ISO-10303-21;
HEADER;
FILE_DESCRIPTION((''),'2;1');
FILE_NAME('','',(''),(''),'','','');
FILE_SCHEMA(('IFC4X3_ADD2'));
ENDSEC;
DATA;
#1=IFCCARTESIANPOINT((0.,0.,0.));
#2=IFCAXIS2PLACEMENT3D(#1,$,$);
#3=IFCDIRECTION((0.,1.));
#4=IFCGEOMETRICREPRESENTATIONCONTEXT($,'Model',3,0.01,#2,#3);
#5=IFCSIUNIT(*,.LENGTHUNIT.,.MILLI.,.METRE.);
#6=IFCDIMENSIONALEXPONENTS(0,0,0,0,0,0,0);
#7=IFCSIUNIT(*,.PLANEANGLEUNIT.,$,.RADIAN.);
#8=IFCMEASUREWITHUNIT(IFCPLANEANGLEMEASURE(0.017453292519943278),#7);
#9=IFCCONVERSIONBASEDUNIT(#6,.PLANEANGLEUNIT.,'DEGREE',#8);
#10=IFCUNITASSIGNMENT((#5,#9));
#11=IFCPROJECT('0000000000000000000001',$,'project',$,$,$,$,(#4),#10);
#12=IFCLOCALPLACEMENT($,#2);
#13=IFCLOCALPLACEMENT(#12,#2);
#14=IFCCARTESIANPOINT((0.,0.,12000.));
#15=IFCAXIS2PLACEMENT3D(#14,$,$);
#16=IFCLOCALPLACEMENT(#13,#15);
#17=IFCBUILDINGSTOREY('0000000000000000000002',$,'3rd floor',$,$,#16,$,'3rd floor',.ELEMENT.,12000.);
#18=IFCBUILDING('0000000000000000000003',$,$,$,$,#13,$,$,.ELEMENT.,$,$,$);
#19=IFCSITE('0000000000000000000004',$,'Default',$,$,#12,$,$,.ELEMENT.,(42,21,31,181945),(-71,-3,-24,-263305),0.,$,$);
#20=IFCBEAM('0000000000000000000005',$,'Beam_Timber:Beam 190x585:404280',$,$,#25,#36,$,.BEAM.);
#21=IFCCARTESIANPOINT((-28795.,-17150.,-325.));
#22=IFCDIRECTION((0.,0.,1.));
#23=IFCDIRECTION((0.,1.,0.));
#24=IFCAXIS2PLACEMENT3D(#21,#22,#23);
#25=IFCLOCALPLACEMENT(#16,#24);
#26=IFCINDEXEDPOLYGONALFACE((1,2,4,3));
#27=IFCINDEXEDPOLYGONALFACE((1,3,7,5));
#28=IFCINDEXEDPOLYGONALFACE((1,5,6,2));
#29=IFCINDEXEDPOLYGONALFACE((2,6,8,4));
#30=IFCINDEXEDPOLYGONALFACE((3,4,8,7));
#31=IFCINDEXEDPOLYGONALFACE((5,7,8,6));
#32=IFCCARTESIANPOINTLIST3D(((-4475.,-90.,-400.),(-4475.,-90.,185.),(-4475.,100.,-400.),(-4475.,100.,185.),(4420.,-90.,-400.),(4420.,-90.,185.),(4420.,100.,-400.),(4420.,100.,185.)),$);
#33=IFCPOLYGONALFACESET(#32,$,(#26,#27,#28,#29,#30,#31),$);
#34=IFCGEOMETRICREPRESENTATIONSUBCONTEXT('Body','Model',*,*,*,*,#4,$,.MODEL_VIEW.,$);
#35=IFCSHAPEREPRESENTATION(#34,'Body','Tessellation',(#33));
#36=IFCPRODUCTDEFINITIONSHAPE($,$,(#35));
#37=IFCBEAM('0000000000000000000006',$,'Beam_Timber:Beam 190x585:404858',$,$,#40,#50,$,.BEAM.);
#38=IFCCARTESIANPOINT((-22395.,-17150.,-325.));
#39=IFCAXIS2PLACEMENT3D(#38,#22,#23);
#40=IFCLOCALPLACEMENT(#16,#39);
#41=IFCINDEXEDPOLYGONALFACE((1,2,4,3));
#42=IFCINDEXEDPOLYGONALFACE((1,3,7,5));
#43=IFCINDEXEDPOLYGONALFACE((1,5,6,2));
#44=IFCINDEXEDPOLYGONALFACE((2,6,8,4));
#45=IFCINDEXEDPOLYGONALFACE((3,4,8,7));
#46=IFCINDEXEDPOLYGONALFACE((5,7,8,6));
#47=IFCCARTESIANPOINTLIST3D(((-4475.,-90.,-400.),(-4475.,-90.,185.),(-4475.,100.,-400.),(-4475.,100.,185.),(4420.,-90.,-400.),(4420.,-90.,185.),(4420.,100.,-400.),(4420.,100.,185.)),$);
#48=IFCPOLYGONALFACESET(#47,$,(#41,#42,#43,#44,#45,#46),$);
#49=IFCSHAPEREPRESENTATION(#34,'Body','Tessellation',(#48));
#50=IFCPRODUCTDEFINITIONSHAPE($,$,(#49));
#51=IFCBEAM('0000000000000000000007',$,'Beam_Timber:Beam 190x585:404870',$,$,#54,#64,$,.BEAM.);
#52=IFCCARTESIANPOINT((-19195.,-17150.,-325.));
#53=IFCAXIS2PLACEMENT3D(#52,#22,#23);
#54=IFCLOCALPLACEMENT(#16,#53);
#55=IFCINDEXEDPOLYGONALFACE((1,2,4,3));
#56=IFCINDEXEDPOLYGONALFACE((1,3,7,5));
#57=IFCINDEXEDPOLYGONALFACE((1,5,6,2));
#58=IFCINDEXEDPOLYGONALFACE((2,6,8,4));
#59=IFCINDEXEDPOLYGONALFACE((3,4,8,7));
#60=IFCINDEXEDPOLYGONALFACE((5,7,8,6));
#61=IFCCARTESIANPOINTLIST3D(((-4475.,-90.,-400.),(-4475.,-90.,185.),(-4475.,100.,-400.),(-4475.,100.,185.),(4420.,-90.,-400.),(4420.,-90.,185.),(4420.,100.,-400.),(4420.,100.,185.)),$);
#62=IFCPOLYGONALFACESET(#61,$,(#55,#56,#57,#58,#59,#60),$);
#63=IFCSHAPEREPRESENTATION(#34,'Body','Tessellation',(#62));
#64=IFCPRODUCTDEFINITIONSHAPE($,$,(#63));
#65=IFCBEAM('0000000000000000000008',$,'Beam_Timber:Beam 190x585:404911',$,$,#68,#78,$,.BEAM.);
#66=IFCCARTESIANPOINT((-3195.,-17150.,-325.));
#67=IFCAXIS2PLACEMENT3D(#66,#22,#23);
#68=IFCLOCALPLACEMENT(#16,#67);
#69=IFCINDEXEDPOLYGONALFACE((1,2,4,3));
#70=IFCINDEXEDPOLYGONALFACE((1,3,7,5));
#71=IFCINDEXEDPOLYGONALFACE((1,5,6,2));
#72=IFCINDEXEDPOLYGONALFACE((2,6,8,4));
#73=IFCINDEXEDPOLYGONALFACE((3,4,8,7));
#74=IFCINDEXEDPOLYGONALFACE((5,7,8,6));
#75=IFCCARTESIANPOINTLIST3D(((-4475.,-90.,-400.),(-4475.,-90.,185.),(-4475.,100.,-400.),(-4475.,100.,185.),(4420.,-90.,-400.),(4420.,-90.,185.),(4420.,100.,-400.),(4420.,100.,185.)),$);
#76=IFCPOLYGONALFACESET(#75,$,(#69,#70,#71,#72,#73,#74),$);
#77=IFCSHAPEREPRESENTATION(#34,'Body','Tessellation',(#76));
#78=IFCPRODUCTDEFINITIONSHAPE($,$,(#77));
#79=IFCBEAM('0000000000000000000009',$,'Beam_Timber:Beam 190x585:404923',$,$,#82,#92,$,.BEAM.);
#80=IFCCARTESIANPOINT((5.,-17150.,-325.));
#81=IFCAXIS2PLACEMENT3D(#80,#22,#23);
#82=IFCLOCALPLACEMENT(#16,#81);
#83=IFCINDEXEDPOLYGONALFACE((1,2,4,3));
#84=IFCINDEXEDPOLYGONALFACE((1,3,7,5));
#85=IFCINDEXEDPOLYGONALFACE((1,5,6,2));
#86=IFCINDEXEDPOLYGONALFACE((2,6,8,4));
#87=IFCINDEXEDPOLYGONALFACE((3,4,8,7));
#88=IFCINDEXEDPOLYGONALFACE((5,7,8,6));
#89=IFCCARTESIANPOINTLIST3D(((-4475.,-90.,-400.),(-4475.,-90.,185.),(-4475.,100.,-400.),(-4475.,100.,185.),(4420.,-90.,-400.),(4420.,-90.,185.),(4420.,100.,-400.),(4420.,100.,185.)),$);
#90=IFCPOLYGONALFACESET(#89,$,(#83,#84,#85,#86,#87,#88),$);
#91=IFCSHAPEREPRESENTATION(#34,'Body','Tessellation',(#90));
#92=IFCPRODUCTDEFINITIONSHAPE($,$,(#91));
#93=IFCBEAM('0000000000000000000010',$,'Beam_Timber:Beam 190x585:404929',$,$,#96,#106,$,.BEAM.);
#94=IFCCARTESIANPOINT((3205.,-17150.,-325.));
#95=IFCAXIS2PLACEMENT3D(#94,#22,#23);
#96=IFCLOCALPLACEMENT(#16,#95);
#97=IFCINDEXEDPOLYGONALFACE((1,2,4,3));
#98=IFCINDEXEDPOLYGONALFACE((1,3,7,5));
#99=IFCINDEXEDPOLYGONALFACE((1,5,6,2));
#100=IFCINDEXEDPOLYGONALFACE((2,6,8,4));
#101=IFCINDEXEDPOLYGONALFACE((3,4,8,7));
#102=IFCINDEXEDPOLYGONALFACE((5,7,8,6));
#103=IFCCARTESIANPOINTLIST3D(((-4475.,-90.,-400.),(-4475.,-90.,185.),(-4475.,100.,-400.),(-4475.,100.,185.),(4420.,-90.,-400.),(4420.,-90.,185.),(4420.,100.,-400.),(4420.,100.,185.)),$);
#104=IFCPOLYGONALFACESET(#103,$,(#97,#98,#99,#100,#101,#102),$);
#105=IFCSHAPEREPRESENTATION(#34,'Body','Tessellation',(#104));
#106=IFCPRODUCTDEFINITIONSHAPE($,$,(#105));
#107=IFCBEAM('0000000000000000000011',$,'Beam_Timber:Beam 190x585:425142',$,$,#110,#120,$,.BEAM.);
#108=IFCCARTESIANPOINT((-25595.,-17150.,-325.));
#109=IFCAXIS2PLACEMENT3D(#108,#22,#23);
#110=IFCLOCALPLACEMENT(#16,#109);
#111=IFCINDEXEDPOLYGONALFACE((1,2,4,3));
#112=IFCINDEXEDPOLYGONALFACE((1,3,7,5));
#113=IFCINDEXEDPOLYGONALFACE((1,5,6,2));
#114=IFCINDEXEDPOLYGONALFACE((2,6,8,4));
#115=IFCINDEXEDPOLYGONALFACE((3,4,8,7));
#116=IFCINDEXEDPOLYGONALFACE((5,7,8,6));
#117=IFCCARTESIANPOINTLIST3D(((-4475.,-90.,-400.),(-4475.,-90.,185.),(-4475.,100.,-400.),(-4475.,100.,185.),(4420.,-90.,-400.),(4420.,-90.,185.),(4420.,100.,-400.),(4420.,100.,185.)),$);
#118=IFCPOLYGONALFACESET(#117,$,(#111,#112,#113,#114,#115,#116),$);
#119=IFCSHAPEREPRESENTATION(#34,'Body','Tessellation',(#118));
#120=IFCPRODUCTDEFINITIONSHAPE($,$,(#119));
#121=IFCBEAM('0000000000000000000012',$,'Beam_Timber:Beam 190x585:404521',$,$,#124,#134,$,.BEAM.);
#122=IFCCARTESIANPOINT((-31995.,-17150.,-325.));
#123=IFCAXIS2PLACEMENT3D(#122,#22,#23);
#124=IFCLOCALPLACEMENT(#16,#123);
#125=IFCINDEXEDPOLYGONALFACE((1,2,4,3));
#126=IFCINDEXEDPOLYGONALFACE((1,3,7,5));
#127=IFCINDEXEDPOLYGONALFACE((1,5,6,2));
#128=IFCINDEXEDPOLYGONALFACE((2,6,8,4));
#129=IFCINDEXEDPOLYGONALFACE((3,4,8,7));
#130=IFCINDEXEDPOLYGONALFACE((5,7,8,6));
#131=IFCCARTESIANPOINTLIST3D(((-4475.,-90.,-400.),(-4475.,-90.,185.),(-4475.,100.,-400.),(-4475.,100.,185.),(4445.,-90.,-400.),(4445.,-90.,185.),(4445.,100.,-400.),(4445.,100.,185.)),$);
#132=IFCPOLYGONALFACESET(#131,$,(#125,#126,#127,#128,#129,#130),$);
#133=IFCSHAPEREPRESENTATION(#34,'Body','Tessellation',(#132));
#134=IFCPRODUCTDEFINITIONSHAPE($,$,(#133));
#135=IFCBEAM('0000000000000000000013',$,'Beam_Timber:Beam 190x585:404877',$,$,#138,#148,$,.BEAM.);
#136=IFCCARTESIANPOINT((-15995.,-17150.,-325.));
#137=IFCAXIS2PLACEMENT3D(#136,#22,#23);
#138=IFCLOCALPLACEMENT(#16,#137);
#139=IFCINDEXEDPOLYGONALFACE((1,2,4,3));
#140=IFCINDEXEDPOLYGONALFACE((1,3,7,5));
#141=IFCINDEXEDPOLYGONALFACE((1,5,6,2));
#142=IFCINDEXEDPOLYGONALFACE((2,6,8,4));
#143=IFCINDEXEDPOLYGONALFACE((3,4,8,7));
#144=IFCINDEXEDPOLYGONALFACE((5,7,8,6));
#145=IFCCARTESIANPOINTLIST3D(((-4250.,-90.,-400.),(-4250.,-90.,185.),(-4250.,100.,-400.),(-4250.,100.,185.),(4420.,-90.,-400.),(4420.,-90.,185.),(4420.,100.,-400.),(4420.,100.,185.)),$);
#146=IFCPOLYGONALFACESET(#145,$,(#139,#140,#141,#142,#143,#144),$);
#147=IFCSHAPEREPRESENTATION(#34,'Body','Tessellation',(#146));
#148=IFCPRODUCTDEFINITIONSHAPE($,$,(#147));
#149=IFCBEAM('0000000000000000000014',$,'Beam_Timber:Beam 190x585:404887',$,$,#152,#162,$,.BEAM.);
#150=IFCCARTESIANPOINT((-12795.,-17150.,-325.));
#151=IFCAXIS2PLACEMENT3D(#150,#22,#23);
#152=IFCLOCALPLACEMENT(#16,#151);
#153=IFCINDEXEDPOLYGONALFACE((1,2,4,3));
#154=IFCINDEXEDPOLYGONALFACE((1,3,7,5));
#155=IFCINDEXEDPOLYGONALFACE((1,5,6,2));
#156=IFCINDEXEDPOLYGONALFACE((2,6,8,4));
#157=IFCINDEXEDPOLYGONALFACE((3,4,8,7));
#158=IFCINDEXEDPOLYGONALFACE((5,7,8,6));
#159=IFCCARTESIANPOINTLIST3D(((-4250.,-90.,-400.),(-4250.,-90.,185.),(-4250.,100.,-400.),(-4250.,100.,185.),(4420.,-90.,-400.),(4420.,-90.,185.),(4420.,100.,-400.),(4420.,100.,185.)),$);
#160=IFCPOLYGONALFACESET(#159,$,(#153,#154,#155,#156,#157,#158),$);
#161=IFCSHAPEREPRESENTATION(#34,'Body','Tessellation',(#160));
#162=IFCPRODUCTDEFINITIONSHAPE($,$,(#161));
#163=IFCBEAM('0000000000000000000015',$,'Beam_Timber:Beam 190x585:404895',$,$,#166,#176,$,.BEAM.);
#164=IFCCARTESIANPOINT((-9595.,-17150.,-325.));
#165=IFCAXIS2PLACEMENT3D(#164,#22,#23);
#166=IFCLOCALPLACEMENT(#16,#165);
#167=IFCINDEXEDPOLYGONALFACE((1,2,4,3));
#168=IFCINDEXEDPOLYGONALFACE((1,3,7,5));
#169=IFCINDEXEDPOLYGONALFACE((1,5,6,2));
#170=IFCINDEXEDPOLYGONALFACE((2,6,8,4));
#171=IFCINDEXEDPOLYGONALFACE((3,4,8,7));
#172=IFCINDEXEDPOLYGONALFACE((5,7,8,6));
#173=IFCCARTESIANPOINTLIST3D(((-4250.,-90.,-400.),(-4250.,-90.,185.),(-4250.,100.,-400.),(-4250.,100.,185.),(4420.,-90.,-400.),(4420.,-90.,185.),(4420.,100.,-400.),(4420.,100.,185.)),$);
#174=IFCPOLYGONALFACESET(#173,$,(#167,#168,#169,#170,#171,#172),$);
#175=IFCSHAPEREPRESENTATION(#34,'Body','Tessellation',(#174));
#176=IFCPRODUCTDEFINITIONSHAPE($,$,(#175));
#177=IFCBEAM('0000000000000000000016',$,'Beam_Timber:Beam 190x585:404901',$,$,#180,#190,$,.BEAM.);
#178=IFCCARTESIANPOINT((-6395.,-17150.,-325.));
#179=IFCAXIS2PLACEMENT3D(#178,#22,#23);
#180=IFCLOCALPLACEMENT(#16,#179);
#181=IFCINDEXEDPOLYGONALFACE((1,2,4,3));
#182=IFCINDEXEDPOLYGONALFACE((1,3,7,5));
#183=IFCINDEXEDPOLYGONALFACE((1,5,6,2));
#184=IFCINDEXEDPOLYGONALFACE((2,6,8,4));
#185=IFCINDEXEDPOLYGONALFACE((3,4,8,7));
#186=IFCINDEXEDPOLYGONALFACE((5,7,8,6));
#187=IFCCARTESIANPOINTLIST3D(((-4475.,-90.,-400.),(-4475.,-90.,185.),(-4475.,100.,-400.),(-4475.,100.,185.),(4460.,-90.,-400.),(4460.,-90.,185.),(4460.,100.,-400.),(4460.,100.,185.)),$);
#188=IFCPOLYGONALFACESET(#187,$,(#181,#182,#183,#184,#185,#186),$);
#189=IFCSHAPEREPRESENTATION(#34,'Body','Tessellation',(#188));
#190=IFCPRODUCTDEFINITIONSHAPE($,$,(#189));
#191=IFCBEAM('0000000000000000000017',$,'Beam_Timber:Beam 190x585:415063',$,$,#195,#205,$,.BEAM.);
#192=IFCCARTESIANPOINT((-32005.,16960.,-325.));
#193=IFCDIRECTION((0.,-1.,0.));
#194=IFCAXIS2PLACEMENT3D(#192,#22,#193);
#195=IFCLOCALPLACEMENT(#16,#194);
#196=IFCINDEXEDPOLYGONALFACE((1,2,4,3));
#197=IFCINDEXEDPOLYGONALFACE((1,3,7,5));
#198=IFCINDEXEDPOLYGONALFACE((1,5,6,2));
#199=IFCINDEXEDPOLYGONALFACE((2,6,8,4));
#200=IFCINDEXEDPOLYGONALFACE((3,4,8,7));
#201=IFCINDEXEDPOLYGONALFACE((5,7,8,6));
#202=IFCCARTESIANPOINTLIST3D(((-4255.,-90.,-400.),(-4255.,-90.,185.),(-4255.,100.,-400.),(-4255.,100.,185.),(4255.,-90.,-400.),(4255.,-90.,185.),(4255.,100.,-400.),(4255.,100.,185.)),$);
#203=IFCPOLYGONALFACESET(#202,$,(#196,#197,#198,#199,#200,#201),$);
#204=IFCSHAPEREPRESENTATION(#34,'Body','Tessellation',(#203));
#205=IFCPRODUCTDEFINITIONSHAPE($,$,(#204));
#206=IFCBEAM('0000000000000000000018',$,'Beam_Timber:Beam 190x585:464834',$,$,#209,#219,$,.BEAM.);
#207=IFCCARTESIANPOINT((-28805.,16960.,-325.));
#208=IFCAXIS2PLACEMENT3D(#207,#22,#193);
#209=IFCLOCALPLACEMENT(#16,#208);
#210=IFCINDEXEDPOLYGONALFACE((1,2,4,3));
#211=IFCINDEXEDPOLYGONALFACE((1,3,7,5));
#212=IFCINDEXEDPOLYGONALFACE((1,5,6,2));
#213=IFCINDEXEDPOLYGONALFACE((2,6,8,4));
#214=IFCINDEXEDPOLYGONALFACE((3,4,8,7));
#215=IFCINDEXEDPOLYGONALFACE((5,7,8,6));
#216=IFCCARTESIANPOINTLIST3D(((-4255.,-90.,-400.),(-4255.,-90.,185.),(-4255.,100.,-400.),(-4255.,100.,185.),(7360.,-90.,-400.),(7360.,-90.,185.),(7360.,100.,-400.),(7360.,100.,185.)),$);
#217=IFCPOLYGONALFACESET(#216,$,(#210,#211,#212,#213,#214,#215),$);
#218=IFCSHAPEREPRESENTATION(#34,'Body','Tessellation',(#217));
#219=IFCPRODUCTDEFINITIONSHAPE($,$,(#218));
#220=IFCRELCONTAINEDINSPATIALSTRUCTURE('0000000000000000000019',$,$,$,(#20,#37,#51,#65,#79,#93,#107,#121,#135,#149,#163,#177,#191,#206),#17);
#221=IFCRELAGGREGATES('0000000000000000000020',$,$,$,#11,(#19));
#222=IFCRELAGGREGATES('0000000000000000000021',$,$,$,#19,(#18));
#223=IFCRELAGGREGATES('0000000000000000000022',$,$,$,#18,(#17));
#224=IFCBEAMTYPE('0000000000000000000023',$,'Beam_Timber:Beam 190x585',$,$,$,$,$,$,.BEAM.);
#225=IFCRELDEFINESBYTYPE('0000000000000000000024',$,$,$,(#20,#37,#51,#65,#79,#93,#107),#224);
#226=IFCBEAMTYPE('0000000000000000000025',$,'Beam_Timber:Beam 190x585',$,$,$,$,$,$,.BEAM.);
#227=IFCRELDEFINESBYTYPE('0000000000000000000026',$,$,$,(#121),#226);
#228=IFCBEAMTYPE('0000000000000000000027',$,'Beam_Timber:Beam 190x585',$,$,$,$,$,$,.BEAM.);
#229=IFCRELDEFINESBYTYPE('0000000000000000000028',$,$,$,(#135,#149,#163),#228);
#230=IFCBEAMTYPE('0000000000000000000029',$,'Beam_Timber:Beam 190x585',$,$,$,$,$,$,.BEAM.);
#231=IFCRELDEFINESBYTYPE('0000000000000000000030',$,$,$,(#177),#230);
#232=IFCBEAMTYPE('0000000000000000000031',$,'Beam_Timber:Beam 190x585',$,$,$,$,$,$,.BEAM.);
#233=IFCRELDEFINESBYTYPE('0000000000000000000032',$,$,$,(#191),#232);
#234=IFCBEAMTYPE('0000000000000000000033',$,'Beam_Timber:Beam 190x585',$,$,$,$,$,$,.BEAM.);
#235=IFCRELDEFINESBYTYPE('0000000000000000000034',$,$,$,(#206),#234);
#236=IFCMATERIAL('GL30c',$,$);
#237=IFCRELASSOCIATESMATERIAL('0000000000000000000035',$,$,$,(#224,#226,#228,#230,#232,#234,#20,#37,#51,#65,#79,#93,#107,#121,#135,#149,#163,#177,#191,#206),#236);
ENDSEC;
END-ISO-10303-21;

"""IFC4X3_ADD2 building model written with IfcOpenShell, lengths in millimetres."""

from ifc_helpers import new_model, entity, si_unit, converted_unit, direction, frame, origin, origin_2d_with_axis, place, context, subcontext, project, spatial, rectangle, extrude, source, transform, mapped, material, material_profile, profile_set, profile_usage, type_object, type_shapes, element, save


model = new_model("IFC4X3_ADD2")

# Units and contexts
model_context = context("Model", 3, precision=0.01, world=origin(), true_north=direction((0.0, 1.0)))
body_context = subcontext(model_context, "Body", "Model", "MODEL_VIEW")
ifc_project = project(units=[si_unit("LENGTHUNIT", "METRE", prefix="MILLI"), converted_unit("PLANEANGLEUNIT", "DEGREE", entity("IfcPlaneAngleMeasure", 0.017453292519943278), si_unit("PLANEANGLEUNIT", "RADIAN"), dimensions=[0, 0, 0, 0, 0, 0, 0])], contexts=[model_context])

# Site, building, storey
site_placement = place(None, origin())
site = spatial("IfcSite", under=ifc_project, at=site_placement, Name="Default", CompositionType="ELEMENT", RefLatitude=(42, 21, 31, 181945), RefLongitude=(-71, -3, -24, -263305), RefElevation=0.0)
building_placement = place(site_placement, origin())
building = spatial("IfcBuilding", under=site, at=building_placement, CompositionType="ELEMENT")
storey_placement = place(building_placement, frame((0.0, 0.0, 12000.0)))
storey = spatial("IfcBuildingStorey", under=building, at=storey_placement, Name="3rd floor", LongName="3rd floor", CompositionType="ELEMENT", Elevation=12000.0)

# Beams
ifc_material_1 = material(Name="GL30c")
ifc_material_profile_1 = material_profile(ifc_material_1, rectangle(XDim=5490.0, YDim=190.0, at=origin_2d_with_axis()), Name="Beam 190x585")
ifc_profile_set_1 = profile_set([ifc_material_profile_1], Name="Beam 190x585")
ifc_profile_usage_1 = profile_usage(ifc_profile_set_1, cardinal=8)
beam_type_1 = type_object("IfcBeamType", Name="Beam_Timber:Beam 190x585", PredefinedType="BEAM", material=ifc_profile_set_1)
shared_shape_1 = source(origin(), body_context, "Body", "SweptSolid", [
    extrude(rectangle(XDim=8895.0, YDim=190.0, at=origin_2d_with_axis()), frame((-27.5, 5.0, -400.0), z_axis=(0.0, 0.0, 1.0), x_axis=(-1.0, 0.0, 0.0)), (0.0, 0.0, 1.0), 585.0),
])
type_shapes(beam_type_1, [shared_shape_1])
for number, where, z_axis, x_axis, name in (
    (1, (-28795.0, -17150.0, -325.0), (0.0, 0.0, 1.0), (0.0, 1.0, 0.0), "Beam_Timber:Beam 190x585:404280"),
    (2, (-22395.0, -17150.0, -325.0), (0.0, 0.0, 1.0), (0.0, 1.0, 0.0), "Beam_Timber:Beam 190x585:404858"),
    (3, (-19195.0, -17150.0, -325.0), (0.0, 0.0, 1.0), (0.0, 1.0, 0.0), "Beam_Timber:Beam 190x585:404870"),
    (4, (-3195.0, -17150.0, -325.0), (0.0, 0.0, 1.0), (0.0, 1.0, 0.0), "Beam_Timber:Beam 190x585:404911"),
    (5, (5.0, -17150.0, -325.0), (0.0, 0.0, 1.0), (0.0, 1.0, 0.0), "Beam_Timber:Beam 190x585:404923"),
    (6, (3205.0, -17150.0, -325.0), (0.0, 0.0, 1.0), (0.0, 1.0, 0.0), "Beam_Timber:Beam 190x585:404929"),
    (7, (-25595.0, -17150.0, -325.0), (0.0, 0.0, 1.0), (0.0, 1.0, 0.0), "Beam_Timber:Beam 190x585:425142"),
):
    element("IfcBeam", number, at=place(storey_placement, frame(where, z_axis=z_axis, x_axis=x_axis)), inside=storey, type_object=beam_type_1, material=ifc_profile_usage_1, Name=name, PredefinedType="BEAM", context=body_context, shape_type="MappedRepresentation", body=[
        mapped(shared_shape_1, transform((0.0, 0.0, 0.0), scale=1.0)),
    ])
beam_type_2 = type_object("IfcBeamType", Name="Beam_Timber:Beam 190x585", PredefinedType="BEAM", material=ifc_profile_set_1)
shared_shape_2 = source(origin(), body_context, "Body", "SweptSolid", [
    extrude(rectangle(XDim=8920.0, YDim=190.0, at=origin_2d_with_axis()), frame((-15.0, 5.0, -400.0), z_axis=(0.0, 0.0, 1.0), x_axis=(-1.0, 0.0, 0.0)), (0.0, 0.0, 1.0), 585.0),
])
type_shapes(beam_type_2, [shared_shape_2])
beam_1_placement = place(storey_placement, frame((-31995.0, -17150.0, -325.0), z_axis=(0.0, 0.0, 1.0), x_axis=(0.0, 1.0, 0.0)))
element("IfcBeam", 8, at=beam_1_placement, inside=storey, type_object=beam_type_2, material=ifc_profile_usage_1, Name="Beam_Timber:Beam 190x585:404521", PredefinedType="BEAM", context=body_context, shape_type="MappedRepresentation", body=[
    mapped(shared_shape_2, transform((0.0, 0.0, 0.0), scale=1.0)),
])
beam_type_3 = type_object("IfcBeamType", Name="Beam_Timber:Beam 190x585", PredefinedType="BEAM", material=ifc_profile_set_1)
shared_shape_3 = source(origin(), body_context, "Body", "SweptSolid", [
    extrude(rectangle(XDim=8670.0, YDim=190.0, at=origin_2d_with_axis()), frame((85.0, 5.0, -400.0), z_axis=(0.0, 0.0, 1.0), x_axis=(-1.0, 0.0, 0.0)), (0.0, 0.0, 1.0), 585.0),
])
type_shapes(beam_type_3, [shared_shape_3])
for number, where, z_axis, x_axis, name in (
    (9, (-15995.0, -17150.0, -325.0), (0.0, 0.0, 1.0), (0.0, 1.0, 0.0), "Beam_Timber:Beam 190x585:404877"),
    (10, (-12795.0, -17150.0, -325.0), (0.0, 0.0, 1.0), (0.0, 1.0, 0.0), "Beam_Timber:Beam 190x585:404887"),
    (11, (-9595.0, -17150.0, -325.0), (0.0, 0.0, 1.0), (0.0, 1.0, 0.0), "Beam_Timber:Beam 190x585:404895"),
):
    element("IfcBeam", number, at=place(storey_placement, frame(where, z_axis=z_axis, x_axis=x_axis)), inside=storey, type_object=beam_type_3, material=ifc_profile_usage_1, Name=name, PredefinedType="BEAM", context=body_context, shape_type="MappedRepresentation", body=[
        mapped(shared_shape_3, transform((0.0, 0.0, 0.0), scale=1.0)),
    ])
beam_type_4 = type_object("IfcBeamType", Name="Beam_Timber:Beam 190x585", PredefinedType="BEAM", material=ifc_profile_set_1)
shared_shape_4 = source(origin(), body_context, "Body", "SweptSolid", [
    extrude(rectangle(XDim=8935.0, YDim=190.0, at=origin_2d_with_axis()), frame((-7.5, 5.0, -400.0), z_axis=(0.0, 0.0, 1.0), x_axis=(-1.0, 0.0, 0.0)), (0.0, 0.0, 1.0), 585.0),
])
type_shapes(beam_type_4, [shared_shape_4])
beam_2_placement = place(storey_placement, frame((-6395.0, -17150.0, -325.0), z_axis=(0.0, 0.0, 1.0), x_axis=(0.0, 1.0, 0.0)))
element("IfcBeam", 12, at=beam_2_placement, inside=storey, type_object=beam_type_4, material=ifc_profile_usage_1, Name="Beam_Timber:Beam 190x585:404901", PredefinedType="BEAM", context=body_context, shape_type="MappedRepresentation", body=[
    mapped(shared_shape_4, transform((0.0, 0.0, 0.0), scale=1.0)),
])
beam_type_5 = type_object("IfcBeamType", Name="Beam_Timber:Beam 190x585", PredefinedType="BEAM", material=ifc_profile_set_1)
shared_shape_5 = source(origin(), body_context, "Body", "SweptSolid", [
    extrude(rectangle(XDim=8510.0, YDim=190.0, at=origin_2d_with_axis()), frame((0.0, 5.0, -400.0), z_axis=(0.0, 0.0, 1.0), x_axis=(-1.0, 0.0, 0.0)), (0.0, 0.0, 1.0), 585.0),
])
type_shapes(beam_type_5, [shared_shape_5])
beam_3_placement = place(storey_placement, frame((-32005.0, 16960.0, -325.0), z_axis=(0.0, 0.0, 1.0), x_axis=(0.0, -1.0, 0.0)))
element("IfcBeam", 13, at=beam_3_placement, inside=storey, type_object=beam_type_5, material=ifc_profile_usage_1, Name="Beam_Timber:Beam 190x585:415063", PredefinedType="BEAM", context=body_context, shape_type="MappedRepresentation", body=[
    mapped(shared_shape_5, transform((0.0, 0.0, 0.0), scale=1.0)),
])
beam_type_6 = type_object("IfcBeamType", Name="Beam_Timber:Beam 190x585", PredefinedType="BEAM", material=ifc_profile_set_1)
shared_shape_6 = source(origin(), body_context, "Body", "SweptSolid", [
    extrude(rectangle(XDim=11615.0, YDim=190.0, at=origin_2d_with_axis()), frame((1552.5, 5.0, -400.0), z_axis=(0.0, 0.0, 1.0), x_axis=(-1.0, 0.0, 0.0)), (0.0, 0.0, 1.0), 585.0),
])
type_shapes(beam_type_6, [shared_shape_6])
beam_4_placement = place(storey_placement, frame((-28805.0, 16960.0, -325.0), z_axis=(0.0, 0.0, 1.0), x_axis=(0.0, -1.0, 0.0)))
element("IfcBeam", 14, at=beam_4_placement, inside=storey, type_object=beam_type_6, material=ifc_profile_usage_1, Name="Beam_Timber:Beam 190x585:464834", PredefinedType="BEAM", context=body_context, shape_type="MappedRepresentation", body=[
    mapped(shared_shape_6, transform((0.0, 0.0, 0.0), scale=1.0)),
])

save(model, "model.ifc")
